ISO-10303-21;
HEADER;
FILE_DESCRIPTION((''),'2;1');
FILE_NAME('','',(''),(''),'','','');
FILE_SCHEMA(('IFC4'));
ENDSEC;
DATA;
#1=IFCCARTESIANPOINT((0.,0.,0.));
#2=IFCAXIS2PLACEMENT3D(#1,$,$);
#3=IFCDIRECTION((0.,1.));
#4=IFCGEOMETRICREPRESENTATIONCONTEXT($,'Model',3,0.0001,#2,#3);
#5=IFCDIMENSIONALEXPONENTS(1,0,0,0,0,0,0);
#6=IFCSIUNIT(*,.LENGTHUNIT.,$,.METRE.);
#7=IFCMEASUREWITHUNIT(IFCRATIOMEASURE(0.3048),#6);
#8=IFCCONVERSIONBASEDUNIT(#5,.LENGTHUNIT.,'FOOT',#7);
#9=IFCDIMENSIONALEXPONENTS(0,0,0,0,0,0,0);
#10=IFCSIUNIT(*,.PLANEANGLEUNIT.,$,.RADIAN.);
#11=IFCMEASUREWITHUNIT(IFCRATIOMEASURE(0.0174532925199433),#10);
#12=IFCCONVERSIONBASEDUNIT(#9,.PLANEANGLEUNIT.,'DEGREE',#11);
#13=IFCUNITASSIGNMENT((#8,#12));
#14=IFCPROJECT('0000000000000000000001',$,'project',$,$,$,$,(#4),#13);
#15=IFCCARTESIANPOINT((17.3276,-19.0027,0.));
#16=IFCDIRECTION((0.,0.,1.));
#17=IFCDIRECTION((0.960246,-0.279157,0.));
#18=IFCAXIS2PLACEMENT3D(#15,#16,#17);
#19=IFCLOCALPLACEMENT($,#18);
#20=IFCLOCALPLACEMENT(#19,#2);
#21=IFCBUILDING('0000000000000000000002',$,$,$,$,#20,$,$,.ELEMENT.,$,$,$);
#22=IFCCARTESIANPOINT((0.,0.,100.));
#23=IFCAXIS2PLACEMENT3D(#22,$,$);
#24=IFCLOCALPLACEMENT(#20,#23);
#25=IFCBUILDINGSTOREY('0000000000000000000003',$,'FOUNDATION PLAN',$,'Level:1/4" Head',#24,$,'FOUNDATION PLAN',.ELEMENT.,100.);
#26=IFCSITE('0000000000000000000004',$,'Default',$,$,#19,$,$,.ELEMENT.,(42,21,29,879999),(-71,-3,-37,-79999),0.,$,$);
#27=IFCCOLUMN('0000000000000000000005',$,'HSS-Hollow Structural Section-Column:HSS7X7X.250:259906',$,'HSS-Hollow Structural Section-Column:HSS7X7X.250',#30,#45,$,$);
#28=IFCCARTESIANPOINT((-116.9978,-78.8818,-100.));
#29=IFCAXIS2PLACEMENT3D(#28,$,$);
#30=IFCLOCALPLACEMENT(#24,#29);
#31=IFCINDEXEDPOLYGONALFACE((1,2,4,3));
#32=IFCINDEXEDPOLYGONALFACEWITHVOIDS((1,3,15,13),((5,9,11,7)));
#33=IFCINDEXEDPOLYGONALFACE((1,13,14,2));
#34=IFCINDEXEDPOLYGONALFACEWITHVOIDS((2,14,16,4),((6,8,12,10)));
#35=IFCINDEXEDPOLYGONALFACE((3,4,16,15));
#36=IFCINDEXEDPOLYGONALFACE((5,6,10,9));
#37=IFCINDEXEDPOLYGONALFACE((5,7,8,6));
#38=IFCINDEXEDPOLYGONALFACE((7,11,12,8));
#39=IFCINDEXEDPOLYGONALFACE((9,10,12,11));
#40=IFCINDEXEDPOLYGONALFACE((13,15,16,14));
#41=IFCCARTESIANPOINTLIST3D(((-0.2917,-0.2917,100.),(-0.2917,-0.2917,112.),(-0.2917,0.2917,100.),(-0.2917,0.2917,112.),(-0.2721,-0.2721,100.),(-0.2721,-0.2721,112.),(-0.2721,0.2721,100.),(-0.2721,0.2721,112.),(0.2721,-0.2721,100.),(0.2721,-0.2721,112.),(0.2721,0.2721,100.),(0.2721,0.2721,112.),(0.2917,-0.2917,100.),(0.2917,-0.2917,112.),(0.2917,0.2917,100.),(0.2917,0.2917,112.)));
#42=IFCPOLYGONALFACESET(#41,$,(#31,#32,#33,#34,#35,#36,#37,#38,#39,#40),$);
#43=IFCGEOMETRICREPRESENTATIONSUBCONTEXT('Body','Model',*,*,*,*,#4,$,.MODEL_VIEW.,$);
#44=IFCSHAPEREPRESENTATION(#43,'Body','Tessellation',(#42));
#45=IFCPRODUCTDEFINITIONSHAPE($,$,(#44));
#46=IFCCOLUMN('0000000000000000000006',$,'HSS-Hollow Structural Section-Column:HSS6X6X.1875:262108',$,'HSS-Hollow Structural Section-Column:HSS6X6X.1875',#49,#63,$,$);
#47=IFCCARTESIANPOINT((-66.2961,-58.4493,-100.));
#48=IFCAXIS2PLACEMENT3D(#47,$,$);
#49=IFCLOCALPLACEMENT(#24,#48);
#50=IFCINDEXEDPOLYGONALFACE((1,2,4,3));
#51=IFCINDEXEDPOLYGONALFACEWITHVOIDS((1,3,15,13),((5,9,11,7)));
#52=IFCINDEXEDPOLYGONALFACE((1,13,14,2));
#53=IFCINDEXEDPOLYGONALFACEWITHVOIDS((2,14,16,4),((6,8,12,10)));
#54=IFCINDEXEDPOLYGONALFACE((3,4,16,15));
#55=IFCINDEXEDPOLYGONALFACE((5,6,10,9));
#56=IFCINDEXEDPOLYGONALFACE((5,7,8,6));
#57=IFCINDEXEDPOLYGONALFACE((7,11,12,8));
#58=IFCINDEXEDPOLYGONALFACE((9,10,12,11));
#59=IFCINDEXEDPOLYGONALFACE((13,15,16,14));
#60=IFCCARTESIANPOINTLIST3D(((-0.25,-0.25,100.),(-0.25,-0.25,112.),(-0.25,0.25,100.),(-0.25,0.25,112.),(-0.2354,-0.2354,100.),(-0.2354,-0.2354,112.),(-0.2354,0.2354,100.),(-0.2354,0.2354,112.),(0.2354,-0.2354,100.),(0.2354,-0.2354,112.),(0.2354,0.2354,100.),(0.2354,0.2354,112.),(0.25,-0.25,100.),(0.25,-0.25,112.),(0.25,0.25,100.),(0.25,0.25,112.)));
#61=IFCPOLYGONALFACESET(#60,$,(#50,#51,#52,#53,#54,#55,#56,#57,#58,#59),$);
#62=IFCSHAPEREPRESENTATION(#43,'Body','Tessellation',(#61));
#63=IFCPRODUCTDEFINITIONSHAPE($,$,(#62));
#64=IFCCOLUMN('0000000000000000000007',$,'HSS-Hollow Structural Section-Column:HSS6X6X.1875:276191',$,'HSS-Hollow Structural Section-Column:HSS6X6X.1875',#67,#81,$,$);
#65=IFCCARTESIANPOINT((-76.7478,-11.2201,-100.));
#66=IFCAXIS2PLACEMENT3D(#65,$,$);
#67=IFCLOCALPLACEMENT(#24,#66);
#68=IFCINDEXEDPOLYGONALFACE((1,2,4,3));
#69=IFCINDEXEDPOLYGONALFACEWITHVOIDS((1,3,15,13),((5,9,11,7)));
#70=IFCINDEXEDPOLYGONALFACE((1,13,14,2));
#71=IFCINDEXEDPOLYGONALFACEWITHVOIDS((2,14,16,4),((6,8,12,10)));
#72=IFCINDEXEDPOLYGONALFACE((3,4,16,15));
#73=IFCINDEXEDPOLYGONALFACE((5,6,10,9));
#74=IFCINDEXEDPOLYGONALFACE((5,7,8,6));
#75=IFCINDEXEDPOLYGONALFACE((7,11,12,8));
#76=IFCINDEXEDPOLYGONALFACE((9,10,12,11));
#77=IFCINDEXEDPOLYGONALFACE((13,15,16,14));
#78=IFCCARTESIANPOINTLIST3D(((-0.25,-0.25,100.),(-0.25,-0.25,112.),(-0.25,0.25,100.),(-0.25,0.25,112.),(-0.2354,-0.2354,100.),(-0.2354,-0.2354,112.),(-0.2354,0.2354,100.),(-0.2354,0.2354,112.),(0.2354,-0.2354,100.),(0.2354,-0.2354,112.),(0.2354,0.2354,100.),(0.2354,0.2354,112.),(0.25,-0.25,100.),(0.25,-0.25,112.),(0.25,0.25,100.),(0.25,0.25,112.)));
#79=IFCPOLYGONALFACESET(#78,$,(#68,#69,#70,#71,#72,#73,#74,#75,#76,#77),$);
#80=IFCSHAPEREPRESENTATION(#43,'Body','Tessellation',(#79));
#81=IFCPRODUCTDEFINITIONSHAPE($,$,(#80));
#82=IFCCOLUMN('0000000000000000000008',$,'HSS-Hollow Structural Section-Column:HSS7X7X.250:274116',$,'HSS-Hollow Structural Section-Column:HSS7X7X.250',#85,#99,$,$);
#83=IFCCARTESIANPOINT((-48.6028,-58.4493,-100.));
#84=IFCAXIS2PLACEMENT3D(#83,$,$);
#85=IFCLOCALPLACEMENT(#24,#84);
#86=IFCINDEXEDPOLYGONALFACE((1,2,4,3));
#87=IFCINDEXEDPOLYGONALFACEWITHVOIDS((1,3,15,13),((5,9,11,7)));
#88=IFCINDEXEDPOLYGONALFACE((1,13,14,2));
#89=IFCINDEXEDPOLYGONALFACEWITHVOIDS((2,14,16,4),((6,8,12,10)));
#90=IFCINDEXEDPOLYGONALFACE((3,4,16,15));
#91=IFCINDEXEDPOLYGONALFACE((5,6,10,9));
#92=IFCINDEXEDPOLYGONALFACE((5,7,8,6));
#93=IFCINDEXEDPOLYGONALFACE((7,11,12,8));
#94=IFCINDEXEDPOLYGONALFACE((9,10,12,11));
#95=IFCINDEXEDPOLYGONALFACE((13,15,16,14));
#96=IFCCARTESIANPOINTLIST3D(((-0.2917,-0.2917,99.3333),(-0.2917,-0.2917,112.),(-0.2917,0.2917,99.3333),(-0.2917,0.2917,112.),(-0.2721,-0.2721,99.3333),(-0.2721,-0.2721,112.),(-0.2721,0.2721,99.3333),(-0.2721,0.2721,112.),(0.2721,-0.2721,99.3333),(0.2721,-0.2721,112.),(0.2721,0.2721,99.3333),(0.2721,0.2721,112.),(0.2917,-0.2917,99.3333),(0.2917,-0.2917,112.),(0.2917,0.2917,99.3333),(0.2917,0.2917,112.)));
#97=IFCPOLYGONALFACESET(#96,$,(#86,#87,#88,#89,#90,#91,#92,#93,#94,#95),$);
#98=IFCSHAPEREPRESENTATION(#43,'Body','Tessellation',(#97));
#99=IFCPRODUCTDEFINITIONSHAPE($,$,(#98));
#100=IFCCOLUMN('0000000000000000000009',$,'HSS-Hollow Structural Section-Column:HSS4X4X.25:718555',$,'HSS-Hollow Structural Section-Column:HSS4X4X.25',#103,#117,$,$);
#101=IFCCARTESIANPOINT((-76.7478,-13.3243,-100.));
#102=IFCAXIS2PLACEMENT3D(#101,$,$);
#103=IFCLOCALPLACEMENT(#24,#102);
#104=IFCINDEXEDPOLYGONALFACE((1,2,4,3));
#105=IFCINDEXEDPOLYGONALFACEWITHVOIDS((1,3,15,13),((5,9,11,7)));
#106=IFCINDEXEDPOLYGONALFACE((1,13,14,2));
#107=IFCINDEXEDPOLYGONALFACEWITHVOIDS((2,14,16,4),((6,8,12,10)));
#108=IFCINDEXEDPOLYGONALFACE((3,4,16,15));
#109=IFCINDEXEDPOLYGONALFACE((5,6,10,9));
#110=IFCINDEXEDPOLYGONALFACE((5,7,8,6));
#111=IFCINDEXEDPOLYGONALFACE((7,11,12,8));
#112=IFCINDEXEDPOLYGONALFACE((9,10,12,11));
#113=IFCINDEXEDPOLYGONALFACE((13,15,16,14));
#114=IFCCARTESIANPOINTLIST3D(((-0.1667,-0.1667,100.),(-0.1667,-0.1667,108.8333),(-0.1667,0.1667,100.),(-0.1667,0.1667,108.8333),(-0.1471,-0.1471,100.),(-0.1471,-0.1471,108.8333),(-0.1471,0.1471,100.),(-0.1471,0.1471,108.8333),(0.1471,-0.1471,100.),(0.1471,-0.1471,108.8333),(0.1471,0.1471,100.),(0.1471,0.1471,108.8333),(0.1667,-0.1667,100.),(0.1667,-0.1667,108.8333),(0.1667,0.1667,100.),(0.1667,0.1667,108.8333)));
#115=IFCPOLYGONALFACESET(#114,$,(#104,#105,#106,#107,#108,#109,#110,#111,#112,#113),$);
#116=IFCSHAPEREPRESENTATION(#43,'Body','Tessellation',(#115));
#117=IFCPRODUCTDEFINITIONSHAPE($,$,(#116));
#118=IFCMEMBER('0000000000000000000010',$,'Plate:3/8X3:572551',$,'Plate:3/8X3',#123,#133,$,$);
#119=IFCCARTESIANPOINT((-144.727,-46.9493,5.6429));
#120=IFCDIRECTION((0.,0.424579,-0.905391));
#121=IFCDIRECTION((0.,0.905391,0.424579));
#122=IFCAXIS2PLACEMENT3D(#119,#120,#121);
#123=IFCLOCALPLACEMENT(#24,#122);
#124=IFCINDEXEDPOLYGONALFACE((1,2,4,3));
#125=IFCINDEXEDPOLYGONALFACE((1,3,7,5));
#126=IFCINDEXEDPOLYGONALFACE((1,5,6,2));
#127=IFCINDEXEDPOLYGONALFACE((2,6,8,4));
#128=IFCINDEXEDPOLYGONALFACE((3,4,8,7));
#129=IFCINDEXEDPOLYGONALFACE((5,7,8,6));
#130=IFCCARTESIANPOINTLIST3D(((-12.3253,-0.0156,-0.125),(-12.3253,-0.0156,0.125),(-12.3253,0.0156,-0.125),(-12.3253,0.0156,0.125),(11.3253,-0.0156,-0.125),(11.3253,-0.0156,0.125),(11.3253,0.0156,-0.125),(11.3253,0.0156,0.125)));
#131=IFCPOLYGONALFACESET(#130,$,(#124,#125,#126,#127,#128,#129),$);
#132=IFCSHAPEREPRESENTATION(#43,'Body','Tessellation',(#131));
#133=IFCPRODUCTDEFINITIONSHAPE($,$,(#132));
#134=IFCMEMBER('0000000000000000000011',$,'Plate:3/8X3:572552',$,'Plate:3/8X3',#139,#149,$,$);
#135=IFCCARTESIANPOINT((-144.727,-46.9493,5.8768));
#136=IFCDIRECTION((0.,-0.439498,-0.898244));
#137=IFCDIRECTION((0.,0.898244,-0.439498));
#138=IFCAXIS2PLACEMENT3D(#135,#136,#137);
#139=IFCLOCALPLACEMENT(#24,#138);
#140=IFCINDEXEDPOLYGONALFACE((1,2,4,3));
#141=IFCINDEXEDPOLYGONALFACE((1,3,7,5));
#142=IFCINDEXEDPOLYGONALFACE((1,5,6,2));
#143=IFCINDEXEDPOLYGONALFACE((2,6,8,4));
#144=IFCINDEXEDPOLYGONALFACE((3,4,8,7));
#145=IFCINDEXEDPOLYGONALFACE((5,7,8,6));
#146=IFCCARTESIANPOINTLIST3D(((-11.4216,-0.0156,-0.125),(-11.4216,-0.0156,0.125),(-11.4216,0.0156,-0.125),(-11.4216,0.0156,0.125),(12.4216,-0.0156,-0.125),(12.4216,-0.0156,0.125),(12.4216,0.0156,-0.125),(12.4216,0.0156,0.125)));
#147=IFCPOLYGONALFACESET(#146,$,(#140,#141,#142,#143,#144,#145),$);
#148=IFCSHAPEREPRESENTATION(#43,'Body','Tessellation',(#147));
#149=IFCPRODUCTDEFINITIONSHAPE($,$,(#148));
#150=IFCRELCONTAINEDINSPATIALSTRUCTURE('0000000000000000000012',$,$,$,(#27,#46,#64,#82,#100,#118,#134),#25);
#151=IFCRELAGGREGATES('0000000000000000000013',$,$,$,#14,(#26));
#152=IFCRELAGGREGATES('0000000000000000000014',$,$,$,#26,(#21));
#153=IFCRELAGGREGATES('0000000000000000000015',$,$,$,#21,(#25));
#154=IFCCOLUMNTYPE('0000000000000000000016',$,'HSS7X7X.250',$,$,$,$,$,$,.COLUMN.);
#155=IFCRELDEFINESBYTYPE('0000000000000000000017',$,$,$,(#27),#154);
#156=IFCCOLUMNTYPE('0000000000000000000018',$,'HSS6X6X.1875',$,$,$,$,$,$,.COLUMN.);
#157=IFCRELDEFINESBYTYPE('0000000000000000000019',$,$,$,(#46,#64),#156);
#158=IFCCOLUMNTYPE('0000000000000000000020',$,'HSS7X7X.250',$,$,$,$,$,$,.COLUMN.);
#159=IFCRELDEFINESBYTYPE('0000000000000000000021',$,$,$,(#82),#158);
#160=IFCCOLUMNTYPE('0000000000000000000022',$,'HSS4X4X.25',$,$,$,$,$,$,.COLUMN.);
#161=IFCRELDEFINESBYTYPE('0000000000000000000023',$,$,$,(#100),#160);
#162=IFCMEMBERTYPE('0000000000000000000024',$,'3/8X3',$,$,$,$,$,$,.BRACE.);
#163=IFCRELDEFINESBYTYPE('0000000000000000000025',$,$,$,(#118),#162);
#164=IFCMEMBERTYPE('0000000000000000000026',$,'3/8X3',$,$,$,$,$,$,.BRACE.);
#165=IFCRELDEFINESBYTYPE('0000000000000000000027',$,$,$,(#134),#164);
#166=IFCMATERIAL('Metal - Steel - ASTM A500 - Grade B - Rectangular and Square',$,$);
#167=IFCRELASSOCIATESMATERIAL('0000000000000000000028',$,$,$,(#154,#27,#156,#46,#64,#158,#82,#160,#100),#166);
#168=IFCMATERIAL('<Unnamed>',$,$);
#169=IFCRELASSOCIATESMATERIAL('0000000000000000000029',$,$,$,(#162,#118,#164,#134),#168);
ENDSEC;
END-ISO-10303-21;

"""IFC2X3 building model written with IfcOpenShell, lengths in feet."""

from ifc_helpers import new_model, entity, si_unit, converted_unit, direction, frame, frame_2d, origin, origin_2d_with_axis, place, context, subcontext, project, spatial, rectangle, extrude, boolean, source, transform, mapped, material, type_object, type_shapes, element, save


model = new_model("IFC2X3")

# Units and contexts
model_context = context("Model", 3, precision=0.0001, world=origin(), true_north=direction((0.0, 1.0)))
body_context = subcontext(model_context, "Body", "Model", "MODEL_VIEW")
ifc_project = project(units=[converted_unit("LENGTHUNIT", "FOOT", entity("IfcRatioMeasure", 0.3048), si_unit("LENGTHUNIT", "METRE"), dimensions=[1, 0, 0, 0, 0, 0, 0]), converted_unit("PLANEANGLEUNIT", "DEGREE", entity("IfcRatioMeasure", 0.0174532925199433), si_unit("PLANEANGLEUNIT", "RADIAN"), dimensions=[0, 0, 0, 0, 0, 0, 0])], contexts=[model_context])

# Site, building, storey
site_placement = place(None, frame((17.3276, -19.0027, 0.0), z_axis=(0.0, 0.0, 1.0), x_axis=(0.960246, -0.279157, 0.0)))
site = spatial("IfcSite", under=ifc_project, at=site_placement, Name="Default", CompositionType="ELEMENT", RefLatitude=(42, 21, 29, 879999), RefLongitude=(-71, -3, -37, -79999), RefElevation=0.0)
building_placement = place(site_placement, origin())
building = spatial("IfcBuilding", under=site, at=building_placement, CompositionType="ELEMENT")
storey_placement = place(building_placement, frame((0.0, 0.0, 100.0)))
storey = spatial("IfcBuildingStorey", under=building, at=storey_placement, Name="FOUNDATION PLAN", ObjectType="Level:1/4\" Head", LongName="FOUNDATION PLAN", CompositionType="ELEMENT", Elevation=100.0)

# Columns
ifc_material_1 = material(Name="Metal - Steel - ASTM A500 - Grade B - Rectangular and Square")
column_type_1 = type_object("IfcColumnType", Name="HSS7X7X.250", PredefinedType="COLUMN", material=ifc_material_1)
shared_shape_1 = source(origin(), body_context, "Body", "SweptSolid", [
    boolean("DIFFERENCE", extrude(rectangle(XDim=0.5833, YDim=0.5833, at=frame_2d((0.0, 0.0), x_axis=(1.0, 0.0))), frame((0.0, 0.0, 100.0), z_axis=(0.0, 0.0, 1.0), x_axis=(0.0, -1.0, 0.0)), (0.0, 0.0, 1.0), 12.0), extrude(rectangle(XDim=0.5443, YDim=0.5443, at=frame_2d((0.0, 0.0), x_axis=(1.0, 0.0))), frame((0.0, 0.0, 112.0), z_axis=(0.0, 0.0, -1.0), x_axis=(0.0, -1.0, 0.0)), (0.0, 0.0, 1.0), 12.0)),
])
type_shapes(column_type_1, [shared_shape_1])
column_1_placement = place(storey_placement, frame((-116.9978, -78.8818, -100.0)))
element("IfcColumn", 1, at=column_1_placement, inside=storey, type_object=column_type_1, material=ifc_material_1, Name="HSS-Hollow Structural Section-Column:HSS7X7X.250:259906", ObjectType="HSS-Hollow Structural Section-Column:HSS7X7X.250", context=body_context, shape_type="MappedRepresentation", body=[
    mapped(shared_shape_1, transform((0.0, 0.0, 0.0), scale=1.0)),
])
column_type_2 = type_object("IfcColumnType", Name="HSS6X6X.1875", PredefinedType="COLUMN", material=ifc_material_1)
shared_shape_2 = source(origin(), body_context, "Body", "SweptSolid", [
    boolean("DIFFERENCE", extrude(rectangle(XDim=0.5, YDim=0.5, at=origin_2d_with_axis()), frame((0.0, 0.0, 100.0), z_axis=(0.0, 0.0, 1.0), x_axis=(0.0, -1.0, 0.0)), (0.0, 0.0, 1.0), 12.0), extrude(rectangle(XDim=0.4707, YDim=0.4707, at=origin_2d_with_axis()), frame((0.0, 0.0, 112.0), z_axis=(0.0, 0.0, -1.0), x_axis=(0.0, -1.0, 0.0)), (0.0, 0.0, 1.0), 12.0)),
])
type_shapes(column_type_2, [shared_shape_2])
for number, where, name in (
    (2, (-66.2961, -58.4493, -100.0), "HSS-Hollow Structural Section-Column:HSS6X6X.1875:262108"),
    (3, (-76.7478, -11.2201, -100.0), "HSS-Hollow Structural Section-Column:HSS6X6X.1875:276191"),
):
    element("IfcColumn", number, at=place(storey_placement, frame(where)), inside=storey, type_object=column_type_2, material=ifc_material_1, Name=name, ObjectType="HSS-Hollow Structural Section-Column:HSS6X6X.1875", context=body_context, shape_type="MappedRepresentation", body=[
        mapped(shared_shape_2, transform((0.0, 0.0, 0.0), scale=1.0)),
    ])
column_type_3 = type_object("IfcColumnType", Name="HSS7X7X.250", PredefinedType="COLUMN", material=ifc_material_1)
shared_shape_3 = source(origin(), body_context, "Body", "SweptSolid", [
    boolean("DIFFERENCE", extrude(rectangle(XDim=0.5833, YDim=0.5833, at=frame_2d((0.0, 0.0), x_axis=(1.0, 0.0))), frame((0.0, 0.0, 99.3333), z_axis=(0.0, 0.0, 1.0), x_axis=(0.0, -1.0, 0.0)), (0.0, 0.0, 1.0), 12.6667), extrude(rectangle(XDim=0.5443, YDim=0.5443, at=frame_2d((0.0, 0.0), x_axis=(1.0, 0.0))), frame((0.0, 0.0, 112.0), z_axis=(0.0, 0.0, -1.0), x_axis=(0.0, -1.0, 0.0)), (0.0, 0.0, 1.0), 12.6667)),
])
type_shapes(column_type_3, [shared_shape_3])
column_2_placement = place(storey_placement, frame((-48.6028, -58.4493, -100.0)))
element("IfcColumn", 4, at=column_2_placement, inside=storey, type_object=column_type_3, material=ifc_material_1, Name="HSS-Hollow Structural Section-Column:HSS7X7X.250:274116", ObjectType="HSS-Hollow Structural Section-Column:HSS7X7X.250", context=body_context, shape_type="MappedRepresentation", body=[
    mapped(shared_shape_3, transform((0.0, 0.0, 0.0), scale=1.0)),
])
column_type_4 = type_object("IfcColumnType", Name="HSS4X4X.25", PredefinedType="COLUMN", material=ifc_material_1)
shared_shape_4 = source(origin(), body_context, "Body", "SweptSolid", [
    boolean("DIFFERENCE", extrude(rectangle(XDim=0.3333, YDim=0.3333, at=origin_2d_with_axis()), frame((0.0, 0.0, 100.0), z_axis=(0.0, 0.0, 1.0), x_axis=(0.0, -1.0, 0.0)), (0.0, 0.0, 1.0), 8.8333), extrude(rectangle(XDim=0.2943, YDim=0.2943, at=origin_2d_with_axis()), frame((0.0, 0.0, 108.8333), z_axis=(0.0, 0.0, -1.0), x_axis=(0.0, -1.0, 0.0)), (0.0, 0.0, 1.0), 8.8333)),
])
type_shapes(column_type_4, [shared_shape_4])
column_3_placement = place(storey_placement, frame((-76.7478, -13.3243, -100.0)))
element("IfcColumn", 5, at=column_3_placement, inside=storey, type_object=column_type_4, material=ifc_material_1, Name="HSS-Hollow Structural Section-Column:HSS4X4X.25:718555", ObjectType="HSS-Hollow Structural Section-Column:HSS4X4X.25", context=body_context, shape_type="MappedRepresentation", body=[
    mapped(shared_shape_4, transform((0.0, 0.0, 0.0), scale=1.0)),
])

# Members
ifc_material_2 = material(Name="<Unnamed>")
member_type_1 = type_object("IfcMemberType", Name="3/8X3", PredefinedType="BRACE", material=ifc_material_2)
shared_shape_5 = source(origin(), body_context, "Body", "SweptSolid", [
    extrude(rectangle(XDim=0.25, YDim=0.0313, at=origin_2d_with_axis()), frame((-12.3253, 0.0, 0.0), z_axis=(1.0, 0.0, 0.0), x_axis=(0.0, 0.0, -1.0)), (0.0, 0.0, 1.0), 23.6506),
])
type_shapes(member_type_1, [shared_shape_5])
member_1_placement = place(storey_placement, frame((-144.727, -46.9493, 5.6429), z_axis=(0.0, 0.424579, -0.905391), x_axis=(0.0, 0.905391, 0.424579)))
element("IfcMember", 6, at=member_1_placement, inside=storey, type_object=member_type_1, material=ifc_material_2, Name="Plate:3/8X3:572551", ObjectType="Plate:3/8X3", context=body_context, shape_type="MappedRepresentation", body=[
    mapped(shared_shape_5, transform((0.0, 0.0, 0.0), scale=1.0)),
])
member_type_2 = type_object("IfcMemberType", Name="3/8X3", PredefinedType="BRACE", material=ifc_material_2)
shared_shape_6 = source(origin(), body_context, "Body", "SweptSolid", [
    extrude(rectangle(XDim=0.25, YDim=0.0313, at=origin_2d_with_axis()), frame((-11.4216, 0.0, 0.0), z_axis=(1.0, 0.0, 0.0), x_axis=(0.0, 0.0, -1.0)), (0.0, 0.0, 1.0), 23.8432),
])
type_shapes(member_type_2, [shared_shape_6])
member_2_placement = place(storey_placement, frame((-144.727, -46.9493, 5.8768), z_axis=(0.0, -0.439498, -0.898244), x_axis=(0.0, 0.898244, -0.439498)))
element("IfcMember", 7, at=member_2_placement, inside=storey, type_object=member_type_2, material=ifc_material_2, Name="Plate:3/8X3:572552", ObjectType="Plate:3/8X3", context=body_context, shape_type="MappedRepresentation", body=[
    mapped(shared_shape_6, transform((0.0, 0.0, 0.0), scale=1.0)),
])

save(model, "model.ifc")
